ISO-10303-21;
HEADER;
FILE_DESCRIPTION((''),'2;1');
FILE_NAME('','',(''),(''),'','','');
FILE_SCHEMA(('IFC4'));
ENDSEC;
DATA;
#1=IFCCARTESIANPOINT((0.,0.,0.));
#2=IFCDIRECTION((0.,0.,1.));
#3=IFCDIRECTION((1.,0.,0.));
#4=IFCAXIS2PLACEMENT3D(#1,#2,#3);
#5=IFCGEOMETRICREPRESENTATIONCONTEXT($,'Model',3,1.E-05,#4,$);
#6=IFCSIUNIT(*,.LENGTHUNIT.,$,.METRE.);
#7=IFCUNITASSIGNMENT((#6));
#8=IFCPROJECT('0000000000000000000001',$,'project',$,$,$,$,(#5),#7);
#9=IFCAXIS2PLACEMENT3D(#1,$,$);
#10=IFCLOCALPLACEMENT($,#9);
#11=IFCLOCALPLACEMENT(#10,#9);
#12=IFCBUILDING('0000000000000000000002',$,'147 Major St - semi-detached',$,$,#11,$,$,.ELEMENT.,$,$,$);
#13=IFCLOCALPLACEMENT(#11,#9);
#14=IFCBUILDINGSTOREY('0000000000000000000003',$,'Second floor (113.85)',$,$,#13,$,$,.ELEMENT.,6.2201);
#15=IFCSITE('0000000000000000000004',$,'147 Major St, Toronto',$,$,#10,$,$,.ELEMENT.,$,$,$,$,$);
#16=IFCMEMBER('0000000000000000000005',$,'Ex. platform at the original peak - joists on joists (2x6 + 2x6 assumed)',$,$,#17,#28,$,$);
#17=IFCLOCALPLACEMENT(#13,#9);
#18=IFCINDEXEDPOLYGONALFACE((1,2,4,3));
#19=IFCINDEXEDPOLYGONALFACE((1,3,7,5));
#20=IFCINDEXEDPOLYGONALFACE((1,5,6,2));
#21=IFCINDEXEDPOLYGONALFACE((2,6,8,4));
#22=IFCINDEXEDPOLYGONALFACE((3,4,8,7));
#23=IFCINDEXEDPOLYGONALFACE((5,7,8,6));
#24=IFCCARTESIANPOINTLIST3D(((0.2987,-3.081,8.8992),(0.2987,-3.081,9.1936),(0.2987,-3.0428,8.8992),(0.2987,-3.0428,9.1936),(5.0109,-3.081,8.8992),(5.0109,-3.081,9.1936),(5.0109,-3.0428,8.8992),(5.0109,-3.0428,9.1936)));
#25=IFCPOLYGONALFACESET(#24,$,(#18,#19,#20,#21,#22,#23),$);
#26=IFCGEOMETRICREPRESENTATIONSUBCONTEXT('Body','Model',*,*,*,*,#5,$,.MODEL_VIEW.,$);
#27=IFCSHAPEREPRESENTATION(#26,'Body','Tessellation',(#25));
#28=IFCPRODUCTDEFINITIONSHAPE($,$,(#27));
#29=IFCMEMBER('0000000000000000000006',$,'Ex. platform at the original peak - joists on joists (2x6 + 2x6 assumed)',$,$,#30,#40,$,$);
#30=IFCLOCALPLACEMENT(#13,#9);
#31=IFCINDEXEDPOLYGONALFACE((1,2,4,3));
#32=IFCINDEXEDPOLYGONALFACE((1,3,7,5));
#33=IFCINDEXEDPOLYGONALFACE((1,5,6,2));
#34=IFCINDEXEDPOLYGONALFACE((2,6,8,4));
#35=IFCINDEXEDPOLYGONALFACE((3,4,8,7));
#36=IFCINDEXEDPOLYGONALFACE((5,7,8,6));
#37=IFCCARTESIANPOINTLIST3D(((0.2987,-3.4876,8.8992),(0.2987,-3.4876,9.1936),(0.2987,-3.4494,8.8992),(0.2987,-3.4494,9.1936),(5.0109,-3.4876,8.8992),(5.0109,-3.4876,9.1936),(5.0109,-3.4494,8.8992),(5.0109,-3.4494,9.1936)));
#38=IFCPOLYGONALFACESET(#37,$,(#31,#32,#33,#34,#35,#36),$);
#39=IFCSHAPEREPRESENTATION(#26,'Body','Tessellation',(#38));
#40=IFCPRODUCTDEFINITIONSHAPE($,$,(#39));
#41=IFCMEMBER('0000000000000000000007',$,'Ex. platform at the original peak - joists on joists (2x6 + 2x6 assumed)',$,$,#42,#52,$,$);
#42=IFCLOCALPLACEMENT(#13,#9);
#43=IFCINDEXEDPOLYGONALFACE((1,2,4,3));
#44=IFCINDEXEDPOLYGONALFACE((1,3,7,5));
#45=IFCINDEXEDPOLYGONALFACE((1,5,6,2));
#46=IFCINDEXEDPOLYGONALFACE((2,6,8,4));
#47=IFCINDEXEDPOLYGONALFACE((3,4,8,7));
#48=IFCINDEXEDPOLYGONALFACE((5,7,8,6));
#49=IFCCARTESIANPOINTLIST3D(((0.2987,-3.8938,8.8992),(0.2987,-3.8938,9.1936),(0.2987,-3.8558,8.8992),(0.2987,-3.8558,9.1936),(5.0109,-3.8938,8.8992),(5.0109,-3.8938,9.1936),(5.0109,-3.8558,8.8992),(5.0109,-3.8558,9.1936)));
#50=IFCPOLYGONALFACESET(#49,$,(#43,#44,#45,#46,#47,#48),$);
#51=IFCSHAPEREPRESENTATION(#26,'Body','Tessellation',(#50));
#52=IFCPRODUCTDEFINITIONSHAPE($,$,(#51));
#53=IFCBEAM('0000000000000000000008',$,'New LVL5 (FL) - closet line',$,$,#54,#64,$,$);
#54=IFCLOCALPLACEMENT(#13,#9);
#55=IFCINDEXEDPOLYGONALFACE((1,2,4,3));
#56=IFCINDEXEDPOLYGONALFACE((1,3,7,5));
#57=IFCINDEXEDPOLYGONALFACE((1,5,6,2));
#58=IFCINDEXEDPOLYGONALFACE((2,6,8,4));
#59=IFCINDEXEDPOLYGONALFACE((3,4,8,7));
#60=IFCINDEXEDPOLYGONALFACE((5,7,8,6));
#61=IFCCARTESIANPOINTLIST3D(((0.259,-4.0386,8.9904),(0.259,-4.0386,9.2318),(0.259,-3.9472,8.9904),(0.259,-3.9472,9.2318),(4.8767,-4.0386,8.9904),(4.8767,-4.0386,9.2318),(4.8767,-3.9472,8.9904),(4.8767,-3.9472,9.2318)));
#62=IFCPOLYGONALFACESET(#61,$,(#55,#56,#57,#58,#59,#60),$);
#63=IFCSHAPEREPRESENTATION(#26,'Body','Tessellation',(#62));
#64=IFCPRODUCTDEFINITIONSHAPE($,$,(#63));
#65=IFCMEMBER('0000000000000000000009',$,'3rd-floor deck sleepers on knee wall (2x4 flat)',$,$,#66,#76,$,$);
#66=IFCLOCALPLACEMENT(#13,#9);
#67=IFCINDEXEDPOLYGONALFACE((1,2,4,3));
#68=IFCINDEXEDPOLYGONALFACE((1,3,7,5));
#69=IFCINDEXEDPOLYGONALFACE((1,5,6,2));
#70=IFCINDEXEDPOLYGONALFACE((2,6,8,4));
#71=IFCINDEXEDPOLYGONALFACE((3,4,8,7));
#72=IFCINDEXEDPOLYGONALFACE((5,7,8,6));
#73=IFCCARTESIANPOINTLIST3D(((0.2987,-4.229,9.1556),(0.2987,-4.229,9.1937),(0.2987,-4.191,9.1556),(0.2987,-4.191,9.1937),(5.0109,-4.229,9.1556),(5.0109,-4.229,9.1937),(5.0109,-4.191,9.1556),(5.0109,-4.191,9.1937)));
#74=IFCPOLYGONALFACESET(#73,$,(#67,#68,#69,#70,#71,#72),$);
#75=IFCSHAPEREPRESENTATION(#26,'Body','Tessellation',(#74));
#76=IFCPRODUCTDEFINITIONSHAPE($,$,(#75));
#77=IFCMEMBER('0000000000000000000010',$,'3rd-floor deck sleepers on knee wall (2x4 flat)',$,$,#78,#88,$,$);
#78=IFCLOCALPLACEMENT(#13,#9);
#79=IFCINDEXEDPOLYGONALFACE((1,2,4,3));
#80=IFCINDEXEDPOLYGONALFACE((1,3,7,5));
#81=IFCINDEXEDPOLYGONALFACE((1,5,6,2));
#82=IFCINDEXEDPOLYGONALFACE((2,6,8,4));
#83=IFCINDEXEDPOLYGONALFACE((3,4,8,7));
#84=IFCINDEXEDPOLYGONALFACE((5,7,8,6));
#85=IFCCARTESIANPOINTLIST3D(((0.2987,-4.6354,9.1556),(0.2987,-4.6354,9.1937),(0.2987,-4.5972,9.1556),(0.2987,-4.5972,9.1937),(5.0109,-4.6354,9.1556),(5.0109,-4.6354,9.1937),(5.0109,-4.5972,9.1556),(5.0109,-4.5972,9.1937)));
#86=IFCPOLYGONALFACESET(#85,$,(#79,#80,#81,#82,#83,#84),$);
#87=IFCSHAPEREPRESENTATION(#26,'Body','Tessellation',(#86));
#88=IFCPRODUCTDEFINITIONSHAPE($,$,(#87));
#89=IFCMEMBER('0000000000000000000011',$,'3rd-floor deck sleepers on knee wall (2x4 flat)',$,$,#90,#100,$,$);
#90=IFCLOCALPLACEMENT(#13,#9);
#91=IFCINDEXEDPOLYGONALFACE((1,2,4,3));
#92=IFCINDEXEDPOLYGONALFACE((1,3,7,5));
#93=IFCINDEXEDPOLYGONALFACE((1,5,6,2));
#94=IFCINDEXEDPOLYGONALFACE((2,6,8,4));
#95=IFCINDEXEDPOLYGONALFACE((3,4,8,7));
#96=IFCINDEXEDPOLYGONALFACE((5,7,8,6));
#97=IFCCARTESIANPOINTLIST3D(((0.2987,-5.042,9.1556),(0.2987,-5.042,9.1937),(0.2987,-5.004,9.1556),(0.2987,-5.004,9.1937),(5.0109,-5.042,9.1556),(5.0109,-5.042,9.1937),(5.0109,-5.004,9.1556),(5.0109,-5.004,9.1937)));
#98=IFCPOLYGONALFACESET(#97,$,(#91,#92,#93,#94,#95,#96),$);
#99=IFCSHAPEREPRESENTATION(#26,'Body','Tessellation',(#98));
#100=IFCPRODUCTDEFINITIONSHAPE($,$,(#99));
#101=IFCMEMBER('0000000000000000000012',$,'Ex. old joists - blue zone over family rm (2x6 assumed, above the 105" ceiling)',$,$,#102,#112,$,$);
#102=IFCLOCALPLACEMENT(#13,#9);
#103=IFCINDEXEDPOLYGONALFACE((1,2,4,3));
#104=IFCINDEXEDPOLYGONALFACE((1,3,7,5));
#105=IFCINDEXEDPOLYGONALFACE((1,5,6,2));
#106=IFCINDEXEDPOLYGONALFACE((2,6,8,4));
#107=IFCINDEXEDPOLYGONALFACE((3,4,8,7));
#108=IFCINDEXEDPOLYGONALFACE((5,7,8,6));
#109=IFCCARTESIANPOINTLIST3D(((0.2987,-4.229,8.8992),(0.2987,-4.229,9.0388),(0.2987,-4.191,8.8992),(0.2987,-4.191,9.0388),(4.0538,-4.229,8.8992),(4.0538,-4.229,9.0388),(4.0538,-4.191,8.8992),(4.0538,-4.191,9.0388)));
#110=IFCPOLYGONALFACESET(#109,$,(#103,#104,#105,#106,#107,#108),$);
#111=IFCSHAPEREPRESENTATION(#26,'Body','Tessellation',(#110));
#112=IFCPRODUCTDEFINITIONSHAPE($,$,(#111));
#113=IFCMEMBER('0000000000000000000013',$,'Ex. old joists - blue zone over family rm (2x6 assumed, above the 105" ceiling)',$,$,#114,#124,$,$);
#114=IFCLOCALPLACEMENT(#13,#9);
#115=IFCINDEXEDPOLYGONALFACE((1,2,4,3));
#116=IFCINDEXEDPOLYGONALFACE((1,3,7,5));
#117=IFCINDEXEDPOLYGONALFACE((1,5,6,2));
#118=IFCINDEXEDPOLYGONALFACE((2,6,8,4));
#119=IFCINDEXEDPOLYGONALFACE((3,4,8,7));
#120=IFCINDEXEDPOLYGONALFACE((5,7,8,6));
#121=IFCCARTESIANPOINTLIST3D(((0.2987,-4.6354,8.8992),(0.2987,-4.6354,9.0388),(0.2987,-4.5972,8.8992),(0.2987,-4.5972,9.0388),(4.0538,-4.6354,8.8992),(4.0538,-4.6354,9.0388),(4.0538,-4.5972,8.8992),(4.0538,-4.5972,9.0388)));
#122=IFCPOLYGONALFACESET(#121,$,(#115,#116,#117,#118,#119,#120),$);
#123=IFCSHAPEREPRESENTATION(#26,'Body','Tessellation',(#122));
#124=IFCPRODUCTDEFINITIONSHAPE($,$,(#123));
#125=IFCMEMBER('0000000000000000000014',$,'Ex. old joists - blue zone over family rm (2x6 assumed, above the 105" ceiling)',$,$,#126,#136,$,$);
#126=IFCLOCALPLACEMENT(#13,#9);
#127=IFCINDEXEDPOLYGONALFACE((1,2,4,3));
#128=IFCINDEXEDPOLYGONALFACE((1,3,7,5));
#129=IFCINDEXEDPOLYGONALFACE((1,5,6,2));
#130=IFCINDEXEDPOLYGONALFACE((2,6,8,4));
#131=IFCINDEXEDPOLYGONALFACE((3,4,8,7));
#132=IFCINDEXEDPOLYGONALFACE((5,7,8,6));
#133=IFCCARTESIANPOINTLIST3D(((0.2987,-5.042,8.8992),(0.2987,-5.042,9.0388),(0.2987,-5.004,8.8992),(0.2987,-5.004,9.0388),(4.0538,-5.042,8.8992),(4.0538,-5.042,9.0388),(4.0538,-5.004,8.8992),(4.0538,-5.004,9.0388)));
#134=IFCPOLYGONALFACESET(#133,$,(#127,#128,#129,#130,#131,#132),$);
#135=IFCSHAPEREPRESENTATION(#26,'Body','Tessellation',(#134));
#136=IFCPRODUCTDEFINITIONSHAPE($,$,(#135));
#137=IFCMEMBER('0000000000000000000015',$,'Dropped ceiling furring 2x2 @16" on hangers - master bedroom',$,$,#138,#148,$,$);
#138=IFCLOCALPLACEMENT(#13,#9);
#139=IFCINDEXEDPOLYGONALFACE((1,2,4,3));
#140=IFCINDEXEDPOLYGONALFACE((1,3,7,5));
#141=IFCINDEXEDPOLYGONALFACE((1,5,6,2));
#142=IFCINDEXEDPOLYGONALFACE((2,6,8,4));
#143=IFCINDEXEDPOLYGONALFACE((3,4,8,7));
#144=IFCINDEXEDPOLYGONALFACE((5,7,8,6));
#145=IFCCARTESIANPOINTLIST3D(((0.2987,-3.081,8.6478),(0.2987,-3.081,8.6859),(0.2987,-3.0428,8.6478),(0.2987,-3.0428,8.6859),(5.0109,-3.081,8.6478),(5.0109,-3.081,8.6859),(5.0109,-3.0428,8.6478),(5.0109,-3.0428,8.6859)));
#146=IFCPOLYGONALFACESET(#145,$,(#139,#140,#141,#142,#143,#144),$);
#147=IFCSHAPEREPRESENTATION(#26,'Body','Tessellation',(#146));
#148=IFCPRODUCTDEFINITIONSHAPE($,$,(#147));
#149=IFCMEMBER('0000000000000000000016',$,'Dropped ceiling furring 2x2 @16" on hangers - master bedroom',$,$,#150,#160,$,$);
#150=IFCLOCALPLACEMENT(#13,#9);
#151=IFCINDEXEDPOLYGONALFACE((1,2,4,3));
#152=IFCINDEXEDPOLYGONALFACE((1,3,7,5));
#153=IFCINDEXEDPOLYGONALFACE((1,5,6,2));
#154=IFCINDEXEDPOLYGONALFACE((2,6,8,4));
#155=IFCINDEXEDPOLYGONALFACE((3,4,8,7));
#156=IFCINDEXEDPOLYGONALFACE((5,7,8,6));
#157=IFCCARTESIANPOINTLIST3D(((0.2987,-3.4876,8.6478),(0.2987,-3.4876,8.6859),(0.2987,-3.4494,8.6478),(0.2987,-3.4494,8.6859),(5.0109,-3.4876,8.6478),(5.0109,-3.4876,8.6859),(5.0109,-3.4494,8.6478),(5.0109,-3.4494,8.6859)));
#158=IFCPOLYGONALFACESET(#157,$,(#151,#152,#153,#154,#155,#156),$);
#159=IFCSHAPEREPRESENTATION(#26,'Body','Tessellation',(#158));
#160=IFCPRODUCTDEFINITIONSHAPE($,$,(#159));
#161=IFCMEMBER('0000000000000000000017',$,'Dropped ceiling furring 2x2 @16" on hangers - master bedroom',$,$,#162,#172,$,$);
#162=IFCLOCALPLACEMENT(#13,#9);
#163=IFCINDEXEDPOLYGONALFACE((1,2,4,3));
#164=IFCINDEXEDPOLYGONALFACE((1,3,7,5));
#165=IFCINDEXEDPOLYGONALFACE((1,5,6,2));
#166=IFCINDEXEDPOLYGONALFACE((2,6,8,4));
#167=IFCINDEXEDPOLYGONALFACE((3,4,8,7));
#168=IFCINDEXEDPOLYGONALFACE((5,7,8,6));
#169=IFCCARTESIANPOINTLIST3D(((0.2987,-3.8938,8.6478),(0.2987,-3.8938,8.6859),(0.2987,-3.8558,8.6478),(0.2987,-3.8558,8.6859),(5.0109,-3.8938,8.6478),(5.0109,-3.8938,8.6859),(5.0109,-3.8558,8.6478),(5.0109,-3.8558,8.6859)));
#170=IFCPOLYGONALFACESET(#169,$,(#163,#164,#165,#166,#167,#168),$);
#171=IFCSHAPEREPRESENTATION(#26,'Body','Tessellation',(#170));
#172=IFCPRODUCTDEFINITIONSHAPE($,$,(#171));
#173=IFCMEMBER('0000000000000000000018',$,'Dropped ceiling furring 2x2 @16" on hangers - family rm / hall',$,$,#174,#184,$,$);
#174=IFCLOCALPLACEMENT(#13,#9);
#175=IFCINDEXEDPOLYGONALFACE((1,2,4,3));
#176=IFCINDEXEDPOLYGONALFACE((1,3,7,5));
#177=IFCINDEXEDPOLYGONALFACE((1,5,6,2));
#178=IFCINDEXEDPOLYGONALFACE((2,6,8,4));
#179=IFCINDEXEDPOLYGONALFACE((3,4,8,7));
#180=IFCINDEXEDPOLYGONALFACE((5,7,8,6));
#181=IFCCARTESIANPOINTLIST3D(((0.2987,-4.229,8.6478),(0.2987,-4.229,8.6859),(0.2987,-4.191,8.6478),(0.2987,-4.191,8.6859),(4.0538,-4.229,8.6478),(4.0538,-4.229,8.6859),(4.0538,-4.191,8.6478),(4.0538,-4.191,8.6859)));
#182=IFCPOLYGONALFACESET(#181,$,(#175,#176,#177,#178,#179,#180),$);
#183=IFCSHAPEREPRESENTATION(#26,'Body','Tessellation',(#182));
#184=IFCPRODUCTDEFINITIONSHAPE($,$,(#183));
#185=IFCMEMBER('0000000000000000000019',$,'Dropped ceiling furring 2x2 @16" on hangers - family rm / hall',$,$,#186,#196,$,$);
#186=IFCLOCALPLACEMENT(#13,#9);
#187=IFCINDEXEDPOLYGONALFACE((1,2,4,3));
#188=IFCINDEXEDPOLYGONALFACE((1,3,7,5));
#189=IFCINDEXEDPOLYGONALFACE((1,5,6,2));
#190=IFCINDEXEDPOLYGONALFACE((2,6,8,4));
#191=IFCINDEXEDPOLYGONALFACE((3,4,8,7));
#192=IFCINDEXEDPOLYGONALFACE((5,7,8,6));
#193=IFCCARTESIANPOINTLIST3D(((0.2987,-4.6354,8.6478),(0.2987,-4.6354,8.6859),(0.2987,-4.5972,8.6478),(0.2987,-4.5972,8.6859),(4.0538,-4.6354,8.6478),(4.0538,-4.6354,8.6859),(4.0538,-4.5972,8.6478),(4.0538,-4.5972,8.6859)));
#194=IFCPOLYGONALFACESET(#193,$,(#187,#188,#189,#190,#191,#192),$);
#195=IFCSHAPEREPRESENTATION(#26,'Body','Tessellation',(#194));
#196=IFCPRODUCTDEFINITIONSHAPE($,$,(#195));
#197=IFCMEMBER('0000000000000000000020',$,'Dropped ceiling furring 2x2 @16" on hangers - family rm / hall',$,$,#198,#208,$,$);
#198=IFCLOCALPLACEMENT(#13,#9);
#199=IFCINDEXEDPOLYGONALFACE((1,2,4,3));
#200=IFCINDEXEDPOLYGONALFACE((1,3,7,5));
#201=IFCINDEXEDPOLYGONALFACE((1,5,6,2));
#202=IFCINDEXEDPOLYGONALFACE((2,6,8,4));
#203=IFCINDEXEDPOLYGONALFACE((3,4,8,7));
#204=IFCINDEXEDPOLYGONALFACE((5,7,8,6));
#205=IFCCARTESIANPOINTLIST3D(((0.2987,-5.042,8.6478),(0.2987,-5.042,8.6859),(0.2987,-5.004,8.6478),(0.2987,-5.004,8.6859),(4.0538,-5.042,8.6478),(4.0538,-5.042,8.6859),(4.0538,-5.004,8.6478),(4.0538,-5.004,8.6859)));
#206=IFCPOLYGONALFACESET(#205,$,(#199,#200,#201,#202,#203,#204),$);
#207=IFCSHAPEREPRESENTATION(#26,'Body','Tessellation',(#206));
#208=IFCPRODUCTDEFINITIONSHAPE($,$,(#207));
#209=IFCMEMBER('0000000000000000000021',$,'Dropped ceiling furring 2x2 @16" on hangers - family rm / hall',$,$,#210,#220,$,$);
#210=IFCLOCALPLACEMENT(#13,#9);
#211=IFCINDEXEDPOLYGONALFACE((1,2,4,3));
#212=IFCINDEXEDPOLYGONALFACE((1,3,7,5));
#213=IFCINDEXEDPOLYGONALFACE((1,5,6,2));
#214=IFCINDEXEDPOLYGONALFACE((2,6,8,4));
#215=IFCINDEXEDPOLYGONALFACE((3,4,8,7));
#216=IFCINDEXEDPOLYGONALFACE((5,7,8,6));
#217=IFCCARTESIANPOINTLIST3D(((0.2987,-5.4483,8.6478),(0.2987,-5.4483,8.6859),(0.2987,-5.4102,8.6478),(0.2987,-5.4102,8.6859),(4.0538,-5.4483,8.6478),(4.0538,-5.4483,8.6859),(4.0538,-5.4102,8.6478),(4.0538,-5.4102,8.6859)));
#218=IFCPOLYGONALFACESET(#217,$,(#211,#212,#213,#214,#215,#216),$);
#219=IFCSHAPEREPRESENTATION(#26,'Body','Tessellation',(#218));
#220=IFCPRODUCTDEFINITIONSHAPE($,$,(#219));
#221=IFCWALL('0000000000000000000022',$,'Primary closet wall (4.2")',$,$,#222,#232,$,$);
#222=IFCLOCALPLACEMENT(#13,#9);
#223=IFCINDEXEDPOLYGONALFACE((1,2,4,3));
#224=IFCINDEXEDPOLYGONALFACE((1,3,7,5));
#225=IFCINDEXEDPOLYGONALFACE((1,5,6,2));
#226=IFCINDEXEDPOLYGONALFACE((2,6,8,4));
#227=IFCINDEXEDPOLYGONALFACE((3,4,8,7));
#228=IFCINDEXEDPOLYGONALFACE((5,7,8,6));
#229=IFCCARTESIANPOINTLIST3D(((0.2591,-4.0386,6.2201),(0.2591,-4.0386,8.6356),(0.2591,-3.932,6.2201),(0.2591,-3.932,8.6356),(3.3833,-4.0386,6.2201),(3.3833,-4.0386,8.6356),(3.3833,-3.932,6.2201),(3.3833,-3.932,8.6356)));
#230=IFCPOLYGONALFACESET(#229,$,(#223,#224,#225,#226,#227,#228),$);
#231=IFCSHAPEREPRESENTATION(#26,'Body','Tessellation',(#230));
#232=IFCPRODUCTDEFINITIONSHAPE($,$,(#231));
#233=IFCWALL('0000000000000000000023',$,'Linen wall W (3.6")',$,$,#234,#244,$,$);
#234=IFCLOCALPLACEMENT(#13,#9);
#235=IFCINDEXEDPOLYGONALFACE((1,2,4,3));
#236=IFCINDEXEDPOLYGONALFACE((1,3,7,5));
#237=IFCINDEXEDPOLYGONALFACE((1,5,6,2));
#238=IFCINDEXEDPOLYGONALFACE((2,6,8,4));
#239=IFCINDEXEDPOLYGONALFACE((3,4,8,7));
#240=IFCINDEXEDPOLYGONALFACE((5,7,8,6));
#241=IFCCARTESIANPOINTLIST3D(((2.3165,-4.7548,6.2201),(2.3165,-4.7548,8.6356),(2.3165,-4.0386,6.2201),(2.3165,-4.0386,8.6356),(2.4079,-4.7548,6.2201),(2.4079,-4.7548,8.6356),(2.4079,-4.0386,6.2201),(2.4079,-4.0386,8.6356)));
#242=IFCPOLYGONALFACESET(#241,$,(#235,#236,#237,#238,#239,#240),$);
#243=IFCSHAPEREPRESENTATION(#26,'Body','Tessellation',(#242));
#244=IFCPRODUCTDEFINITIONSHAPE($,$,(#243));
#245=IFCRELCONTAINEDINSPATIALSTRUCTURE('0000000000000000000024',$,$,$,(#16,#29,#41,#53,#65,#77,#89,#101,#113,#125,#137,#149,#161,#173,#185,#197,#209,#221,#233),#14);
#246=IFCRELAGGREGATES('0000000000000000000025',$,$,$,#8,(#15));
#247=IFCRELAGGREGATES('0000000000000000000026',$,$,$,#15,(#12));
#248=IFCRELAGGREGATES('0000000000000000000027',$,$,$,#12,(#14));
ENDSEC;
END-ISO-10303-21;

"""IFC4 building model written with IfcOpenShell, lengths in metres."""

from ifc_helpers import new_model, si_unit, frame, origin, origin_with_axes, place, context, subcontext, project, spatial, rectangle, extrude, element, save


model = new_model("IFC4")

# Units and contexts
model_context = context("Model", 3, precision=1e-05, world=origin_with_axes())
body_context = subcontext(model_context, "Body", "Model", "MODEL_VIEW")
ifc_project = project(units=[si_unit("LENGTHUNIT", "METRE")], contexts=[model_context])

# Site, building, storey
site_placement = place(None, origin())
site = spatial("IfcSite", under=ifc_project, at=site_placement, Name="147 Major St, Toronto", CompositionType="ELEMENT")
building_placement = place(site_placement, origin())
building = spatial("IfcBuilding", under=site, at=building_placement, Name="147 Major St - semi-detached", CompositionType="ELEMENT")
storey_placement = place(building_placement, origin())
storey = spatial("IfcBuildingStorey", under=building, at=storey_placement, Name="Second floor (113.85)", CompositionType="ELEMENT", Elevation=6.2201)

# Members
for number, where, name in (
    (1, (2.6548, -3.0619, 8.8992), "Ex. platform at the original peak - joists on joists (2x6 + 2x6 assumed)"),
    (2, (2.6548, -3.4685, 8.8992), "Ex. platform at the original peak - joists on joists (2x6 + 2x6 assumed)"),
    (3, (2.6548, -3.8748, 8.8992), "Ex. platform at the original peak - joists on joists (2x6 + 2x6 assumed)"),
):
    element("IfcMember", number, at=place(storey_placement, frame(where)), inside=storey, Name=name, context=body_context, shape_type="SweptSolid", body=[
        extrude(rectangle(XDim=4.7122, YDim=0.0381), origin_with_axes(), (0.0, 0.0, 1.0), 0.2944),
    ])

# Beam
beam_placement = place(storey_placement, frame((2.5679, -3.9929, 8.9904)))
element("IfcBeam", 4, at=beam_placement, inside=storey, Name="New LVL5 (FL) - closet line", context=body_context, shape_type="SweptSolid", body=[
    extrude(rectangle(XDim=4.6177, YDim=0.0914), origin_with_axes(), (0.0, 0.0, 1.0), 0.2414),
])

# Members
for number, where, name in (
    (5, (2.6548, -4.21, 9.1556), "3rd-floor deck sleepers on knee wall (2x4 flat)"),
    (6, (2.6548, -4.6163, 9.1556), "3rd-floor deck sleepers on knee wall (2x4 flat)"),
    (7, (2.6548, -5.023, 9.1556), "3rd-floor deck sleepers on knee wall (2x4 flat)"),
):
    element("IfcMember", number, at=place(storey_placement, frame(where)), inside=storey, Name=name, context=body_context, shape_type="SweptSolid", body=[
        extrude(rectangle(XDim=4.7122, YDim=0.0381), origin_with_axes(), (0.0, 0.0, 1.0), 0.0381),
    ])
for number, where, name in (
    (8, (2.1763, -4.21, 8.8992), "Ex. old joists - blue zone over family rm (2x6 assumed, above the 105\" ceiling)"),
    (9, (2.1763, -4.6163, 8.8992), "Ex. old joists - blue zone over family rm (2x6 assumed, above the 105\" ceiling)"),
    (10, (2.1763, -5.023, 8.8992), "Ex. old joists - blue zone over family rm (2x6 assumed, above the 105\" ceiling)"),
):
    element("IfcMember", number, at=place(storey_placement, frame(where)), inside=storey, Name=name, context=body_context, shape_type="SweptSolid", body=[
        extrude(rectangle(XDim=3.7551, YDim=0.0381), origin_with_axes(), (0.0, 0.0, 1.0), 0.1396),
    ])
for number, where, name in (
    (11, (2.6548, -3.0619, 8.6478), "Dropped ceiling furring 2x2 @16\" on hangers - master bedroom"),
    (12, (2.6548, -3.4685, 8.6478), "Dropped ceiling furring 2x2 @16\" on hangers - master bedroom"),
    (13, (2.6548, -3.8748, 8.6478), "Dropped ceiling furring 2x2 @16\" on hangers - master bedroom"),
):
    element("IfcMember", number, at=place(storey_placement, frame(where)), inside=storey, Name=name, context=body_context, shape_type="SweptSolid", body=[
        extrude(rectangle(XDim=4.7122, YDim=0.0381), origin_with_axes(), (0.0, 0.0, 1.0), 0.0381),
    ])
for number, where, name in (
    (14, (2.1763, -4.21, 8.6478), "Dropped ceiling furring 2x2 @16\" on hangers - family rm / hall"),
    (15, (2.1763, -4.6163, 8.6478), "Dropped ceiling furring 2x2 @16\" on hangers - family rm / hall"),
    (16, (2.1763, -5.023, 8.6478), "Dropped ceiling furring 2x2 @16\" on hangers - family rm / hall"),
    (17, (2.1763, -5.4293, 8.6478), "Dropped ceiling furring 2x2 @16\" on hangers - family rm / hall"),
):
    element("IfcMember", number, at=place(storey_placement, frame(where)), inside=storey, Name=name, context=body_context, shape_type="SweptSolid", body=[
        extrude(rectangle(XDim=3.7551, YDim=0.0381), origin_with_axes(), (0.0, 0.0, 1.0), 0.0381),
    ])

# Walls
wall_1_placement = place(storey_placement, frame((1.8212, -3.9853, 6.2201)))
element("IfcWall", 18, at=wall_1_placement, inside=storey, Name="Primary closet wall (4.2\")", context=body_context, shape_type="SweptSolid", body=[
    extrude(rectangle(XDim=3.1242, YDim=0.1067), origin_with_axes(), (0.0, 0.0, 1.0), 2.4155),
])
for number, where, name in (
    (19, (2.3622, -4.3967, 6.2201), "Linen wall W (3.6\")"),
):
    element("IfcWall", number, at=place(storey_placement, frame(where)), inside=storey, Name=name, context=body_context, shape_type="SweptSolid", body=[
        extrude(rectangle(XDim=0.0914, YDim=0.7163), origin_with_axes(), (0.0, 0.0, 1.0), 2.4155),
    ])

save(model, "model.ifc")
